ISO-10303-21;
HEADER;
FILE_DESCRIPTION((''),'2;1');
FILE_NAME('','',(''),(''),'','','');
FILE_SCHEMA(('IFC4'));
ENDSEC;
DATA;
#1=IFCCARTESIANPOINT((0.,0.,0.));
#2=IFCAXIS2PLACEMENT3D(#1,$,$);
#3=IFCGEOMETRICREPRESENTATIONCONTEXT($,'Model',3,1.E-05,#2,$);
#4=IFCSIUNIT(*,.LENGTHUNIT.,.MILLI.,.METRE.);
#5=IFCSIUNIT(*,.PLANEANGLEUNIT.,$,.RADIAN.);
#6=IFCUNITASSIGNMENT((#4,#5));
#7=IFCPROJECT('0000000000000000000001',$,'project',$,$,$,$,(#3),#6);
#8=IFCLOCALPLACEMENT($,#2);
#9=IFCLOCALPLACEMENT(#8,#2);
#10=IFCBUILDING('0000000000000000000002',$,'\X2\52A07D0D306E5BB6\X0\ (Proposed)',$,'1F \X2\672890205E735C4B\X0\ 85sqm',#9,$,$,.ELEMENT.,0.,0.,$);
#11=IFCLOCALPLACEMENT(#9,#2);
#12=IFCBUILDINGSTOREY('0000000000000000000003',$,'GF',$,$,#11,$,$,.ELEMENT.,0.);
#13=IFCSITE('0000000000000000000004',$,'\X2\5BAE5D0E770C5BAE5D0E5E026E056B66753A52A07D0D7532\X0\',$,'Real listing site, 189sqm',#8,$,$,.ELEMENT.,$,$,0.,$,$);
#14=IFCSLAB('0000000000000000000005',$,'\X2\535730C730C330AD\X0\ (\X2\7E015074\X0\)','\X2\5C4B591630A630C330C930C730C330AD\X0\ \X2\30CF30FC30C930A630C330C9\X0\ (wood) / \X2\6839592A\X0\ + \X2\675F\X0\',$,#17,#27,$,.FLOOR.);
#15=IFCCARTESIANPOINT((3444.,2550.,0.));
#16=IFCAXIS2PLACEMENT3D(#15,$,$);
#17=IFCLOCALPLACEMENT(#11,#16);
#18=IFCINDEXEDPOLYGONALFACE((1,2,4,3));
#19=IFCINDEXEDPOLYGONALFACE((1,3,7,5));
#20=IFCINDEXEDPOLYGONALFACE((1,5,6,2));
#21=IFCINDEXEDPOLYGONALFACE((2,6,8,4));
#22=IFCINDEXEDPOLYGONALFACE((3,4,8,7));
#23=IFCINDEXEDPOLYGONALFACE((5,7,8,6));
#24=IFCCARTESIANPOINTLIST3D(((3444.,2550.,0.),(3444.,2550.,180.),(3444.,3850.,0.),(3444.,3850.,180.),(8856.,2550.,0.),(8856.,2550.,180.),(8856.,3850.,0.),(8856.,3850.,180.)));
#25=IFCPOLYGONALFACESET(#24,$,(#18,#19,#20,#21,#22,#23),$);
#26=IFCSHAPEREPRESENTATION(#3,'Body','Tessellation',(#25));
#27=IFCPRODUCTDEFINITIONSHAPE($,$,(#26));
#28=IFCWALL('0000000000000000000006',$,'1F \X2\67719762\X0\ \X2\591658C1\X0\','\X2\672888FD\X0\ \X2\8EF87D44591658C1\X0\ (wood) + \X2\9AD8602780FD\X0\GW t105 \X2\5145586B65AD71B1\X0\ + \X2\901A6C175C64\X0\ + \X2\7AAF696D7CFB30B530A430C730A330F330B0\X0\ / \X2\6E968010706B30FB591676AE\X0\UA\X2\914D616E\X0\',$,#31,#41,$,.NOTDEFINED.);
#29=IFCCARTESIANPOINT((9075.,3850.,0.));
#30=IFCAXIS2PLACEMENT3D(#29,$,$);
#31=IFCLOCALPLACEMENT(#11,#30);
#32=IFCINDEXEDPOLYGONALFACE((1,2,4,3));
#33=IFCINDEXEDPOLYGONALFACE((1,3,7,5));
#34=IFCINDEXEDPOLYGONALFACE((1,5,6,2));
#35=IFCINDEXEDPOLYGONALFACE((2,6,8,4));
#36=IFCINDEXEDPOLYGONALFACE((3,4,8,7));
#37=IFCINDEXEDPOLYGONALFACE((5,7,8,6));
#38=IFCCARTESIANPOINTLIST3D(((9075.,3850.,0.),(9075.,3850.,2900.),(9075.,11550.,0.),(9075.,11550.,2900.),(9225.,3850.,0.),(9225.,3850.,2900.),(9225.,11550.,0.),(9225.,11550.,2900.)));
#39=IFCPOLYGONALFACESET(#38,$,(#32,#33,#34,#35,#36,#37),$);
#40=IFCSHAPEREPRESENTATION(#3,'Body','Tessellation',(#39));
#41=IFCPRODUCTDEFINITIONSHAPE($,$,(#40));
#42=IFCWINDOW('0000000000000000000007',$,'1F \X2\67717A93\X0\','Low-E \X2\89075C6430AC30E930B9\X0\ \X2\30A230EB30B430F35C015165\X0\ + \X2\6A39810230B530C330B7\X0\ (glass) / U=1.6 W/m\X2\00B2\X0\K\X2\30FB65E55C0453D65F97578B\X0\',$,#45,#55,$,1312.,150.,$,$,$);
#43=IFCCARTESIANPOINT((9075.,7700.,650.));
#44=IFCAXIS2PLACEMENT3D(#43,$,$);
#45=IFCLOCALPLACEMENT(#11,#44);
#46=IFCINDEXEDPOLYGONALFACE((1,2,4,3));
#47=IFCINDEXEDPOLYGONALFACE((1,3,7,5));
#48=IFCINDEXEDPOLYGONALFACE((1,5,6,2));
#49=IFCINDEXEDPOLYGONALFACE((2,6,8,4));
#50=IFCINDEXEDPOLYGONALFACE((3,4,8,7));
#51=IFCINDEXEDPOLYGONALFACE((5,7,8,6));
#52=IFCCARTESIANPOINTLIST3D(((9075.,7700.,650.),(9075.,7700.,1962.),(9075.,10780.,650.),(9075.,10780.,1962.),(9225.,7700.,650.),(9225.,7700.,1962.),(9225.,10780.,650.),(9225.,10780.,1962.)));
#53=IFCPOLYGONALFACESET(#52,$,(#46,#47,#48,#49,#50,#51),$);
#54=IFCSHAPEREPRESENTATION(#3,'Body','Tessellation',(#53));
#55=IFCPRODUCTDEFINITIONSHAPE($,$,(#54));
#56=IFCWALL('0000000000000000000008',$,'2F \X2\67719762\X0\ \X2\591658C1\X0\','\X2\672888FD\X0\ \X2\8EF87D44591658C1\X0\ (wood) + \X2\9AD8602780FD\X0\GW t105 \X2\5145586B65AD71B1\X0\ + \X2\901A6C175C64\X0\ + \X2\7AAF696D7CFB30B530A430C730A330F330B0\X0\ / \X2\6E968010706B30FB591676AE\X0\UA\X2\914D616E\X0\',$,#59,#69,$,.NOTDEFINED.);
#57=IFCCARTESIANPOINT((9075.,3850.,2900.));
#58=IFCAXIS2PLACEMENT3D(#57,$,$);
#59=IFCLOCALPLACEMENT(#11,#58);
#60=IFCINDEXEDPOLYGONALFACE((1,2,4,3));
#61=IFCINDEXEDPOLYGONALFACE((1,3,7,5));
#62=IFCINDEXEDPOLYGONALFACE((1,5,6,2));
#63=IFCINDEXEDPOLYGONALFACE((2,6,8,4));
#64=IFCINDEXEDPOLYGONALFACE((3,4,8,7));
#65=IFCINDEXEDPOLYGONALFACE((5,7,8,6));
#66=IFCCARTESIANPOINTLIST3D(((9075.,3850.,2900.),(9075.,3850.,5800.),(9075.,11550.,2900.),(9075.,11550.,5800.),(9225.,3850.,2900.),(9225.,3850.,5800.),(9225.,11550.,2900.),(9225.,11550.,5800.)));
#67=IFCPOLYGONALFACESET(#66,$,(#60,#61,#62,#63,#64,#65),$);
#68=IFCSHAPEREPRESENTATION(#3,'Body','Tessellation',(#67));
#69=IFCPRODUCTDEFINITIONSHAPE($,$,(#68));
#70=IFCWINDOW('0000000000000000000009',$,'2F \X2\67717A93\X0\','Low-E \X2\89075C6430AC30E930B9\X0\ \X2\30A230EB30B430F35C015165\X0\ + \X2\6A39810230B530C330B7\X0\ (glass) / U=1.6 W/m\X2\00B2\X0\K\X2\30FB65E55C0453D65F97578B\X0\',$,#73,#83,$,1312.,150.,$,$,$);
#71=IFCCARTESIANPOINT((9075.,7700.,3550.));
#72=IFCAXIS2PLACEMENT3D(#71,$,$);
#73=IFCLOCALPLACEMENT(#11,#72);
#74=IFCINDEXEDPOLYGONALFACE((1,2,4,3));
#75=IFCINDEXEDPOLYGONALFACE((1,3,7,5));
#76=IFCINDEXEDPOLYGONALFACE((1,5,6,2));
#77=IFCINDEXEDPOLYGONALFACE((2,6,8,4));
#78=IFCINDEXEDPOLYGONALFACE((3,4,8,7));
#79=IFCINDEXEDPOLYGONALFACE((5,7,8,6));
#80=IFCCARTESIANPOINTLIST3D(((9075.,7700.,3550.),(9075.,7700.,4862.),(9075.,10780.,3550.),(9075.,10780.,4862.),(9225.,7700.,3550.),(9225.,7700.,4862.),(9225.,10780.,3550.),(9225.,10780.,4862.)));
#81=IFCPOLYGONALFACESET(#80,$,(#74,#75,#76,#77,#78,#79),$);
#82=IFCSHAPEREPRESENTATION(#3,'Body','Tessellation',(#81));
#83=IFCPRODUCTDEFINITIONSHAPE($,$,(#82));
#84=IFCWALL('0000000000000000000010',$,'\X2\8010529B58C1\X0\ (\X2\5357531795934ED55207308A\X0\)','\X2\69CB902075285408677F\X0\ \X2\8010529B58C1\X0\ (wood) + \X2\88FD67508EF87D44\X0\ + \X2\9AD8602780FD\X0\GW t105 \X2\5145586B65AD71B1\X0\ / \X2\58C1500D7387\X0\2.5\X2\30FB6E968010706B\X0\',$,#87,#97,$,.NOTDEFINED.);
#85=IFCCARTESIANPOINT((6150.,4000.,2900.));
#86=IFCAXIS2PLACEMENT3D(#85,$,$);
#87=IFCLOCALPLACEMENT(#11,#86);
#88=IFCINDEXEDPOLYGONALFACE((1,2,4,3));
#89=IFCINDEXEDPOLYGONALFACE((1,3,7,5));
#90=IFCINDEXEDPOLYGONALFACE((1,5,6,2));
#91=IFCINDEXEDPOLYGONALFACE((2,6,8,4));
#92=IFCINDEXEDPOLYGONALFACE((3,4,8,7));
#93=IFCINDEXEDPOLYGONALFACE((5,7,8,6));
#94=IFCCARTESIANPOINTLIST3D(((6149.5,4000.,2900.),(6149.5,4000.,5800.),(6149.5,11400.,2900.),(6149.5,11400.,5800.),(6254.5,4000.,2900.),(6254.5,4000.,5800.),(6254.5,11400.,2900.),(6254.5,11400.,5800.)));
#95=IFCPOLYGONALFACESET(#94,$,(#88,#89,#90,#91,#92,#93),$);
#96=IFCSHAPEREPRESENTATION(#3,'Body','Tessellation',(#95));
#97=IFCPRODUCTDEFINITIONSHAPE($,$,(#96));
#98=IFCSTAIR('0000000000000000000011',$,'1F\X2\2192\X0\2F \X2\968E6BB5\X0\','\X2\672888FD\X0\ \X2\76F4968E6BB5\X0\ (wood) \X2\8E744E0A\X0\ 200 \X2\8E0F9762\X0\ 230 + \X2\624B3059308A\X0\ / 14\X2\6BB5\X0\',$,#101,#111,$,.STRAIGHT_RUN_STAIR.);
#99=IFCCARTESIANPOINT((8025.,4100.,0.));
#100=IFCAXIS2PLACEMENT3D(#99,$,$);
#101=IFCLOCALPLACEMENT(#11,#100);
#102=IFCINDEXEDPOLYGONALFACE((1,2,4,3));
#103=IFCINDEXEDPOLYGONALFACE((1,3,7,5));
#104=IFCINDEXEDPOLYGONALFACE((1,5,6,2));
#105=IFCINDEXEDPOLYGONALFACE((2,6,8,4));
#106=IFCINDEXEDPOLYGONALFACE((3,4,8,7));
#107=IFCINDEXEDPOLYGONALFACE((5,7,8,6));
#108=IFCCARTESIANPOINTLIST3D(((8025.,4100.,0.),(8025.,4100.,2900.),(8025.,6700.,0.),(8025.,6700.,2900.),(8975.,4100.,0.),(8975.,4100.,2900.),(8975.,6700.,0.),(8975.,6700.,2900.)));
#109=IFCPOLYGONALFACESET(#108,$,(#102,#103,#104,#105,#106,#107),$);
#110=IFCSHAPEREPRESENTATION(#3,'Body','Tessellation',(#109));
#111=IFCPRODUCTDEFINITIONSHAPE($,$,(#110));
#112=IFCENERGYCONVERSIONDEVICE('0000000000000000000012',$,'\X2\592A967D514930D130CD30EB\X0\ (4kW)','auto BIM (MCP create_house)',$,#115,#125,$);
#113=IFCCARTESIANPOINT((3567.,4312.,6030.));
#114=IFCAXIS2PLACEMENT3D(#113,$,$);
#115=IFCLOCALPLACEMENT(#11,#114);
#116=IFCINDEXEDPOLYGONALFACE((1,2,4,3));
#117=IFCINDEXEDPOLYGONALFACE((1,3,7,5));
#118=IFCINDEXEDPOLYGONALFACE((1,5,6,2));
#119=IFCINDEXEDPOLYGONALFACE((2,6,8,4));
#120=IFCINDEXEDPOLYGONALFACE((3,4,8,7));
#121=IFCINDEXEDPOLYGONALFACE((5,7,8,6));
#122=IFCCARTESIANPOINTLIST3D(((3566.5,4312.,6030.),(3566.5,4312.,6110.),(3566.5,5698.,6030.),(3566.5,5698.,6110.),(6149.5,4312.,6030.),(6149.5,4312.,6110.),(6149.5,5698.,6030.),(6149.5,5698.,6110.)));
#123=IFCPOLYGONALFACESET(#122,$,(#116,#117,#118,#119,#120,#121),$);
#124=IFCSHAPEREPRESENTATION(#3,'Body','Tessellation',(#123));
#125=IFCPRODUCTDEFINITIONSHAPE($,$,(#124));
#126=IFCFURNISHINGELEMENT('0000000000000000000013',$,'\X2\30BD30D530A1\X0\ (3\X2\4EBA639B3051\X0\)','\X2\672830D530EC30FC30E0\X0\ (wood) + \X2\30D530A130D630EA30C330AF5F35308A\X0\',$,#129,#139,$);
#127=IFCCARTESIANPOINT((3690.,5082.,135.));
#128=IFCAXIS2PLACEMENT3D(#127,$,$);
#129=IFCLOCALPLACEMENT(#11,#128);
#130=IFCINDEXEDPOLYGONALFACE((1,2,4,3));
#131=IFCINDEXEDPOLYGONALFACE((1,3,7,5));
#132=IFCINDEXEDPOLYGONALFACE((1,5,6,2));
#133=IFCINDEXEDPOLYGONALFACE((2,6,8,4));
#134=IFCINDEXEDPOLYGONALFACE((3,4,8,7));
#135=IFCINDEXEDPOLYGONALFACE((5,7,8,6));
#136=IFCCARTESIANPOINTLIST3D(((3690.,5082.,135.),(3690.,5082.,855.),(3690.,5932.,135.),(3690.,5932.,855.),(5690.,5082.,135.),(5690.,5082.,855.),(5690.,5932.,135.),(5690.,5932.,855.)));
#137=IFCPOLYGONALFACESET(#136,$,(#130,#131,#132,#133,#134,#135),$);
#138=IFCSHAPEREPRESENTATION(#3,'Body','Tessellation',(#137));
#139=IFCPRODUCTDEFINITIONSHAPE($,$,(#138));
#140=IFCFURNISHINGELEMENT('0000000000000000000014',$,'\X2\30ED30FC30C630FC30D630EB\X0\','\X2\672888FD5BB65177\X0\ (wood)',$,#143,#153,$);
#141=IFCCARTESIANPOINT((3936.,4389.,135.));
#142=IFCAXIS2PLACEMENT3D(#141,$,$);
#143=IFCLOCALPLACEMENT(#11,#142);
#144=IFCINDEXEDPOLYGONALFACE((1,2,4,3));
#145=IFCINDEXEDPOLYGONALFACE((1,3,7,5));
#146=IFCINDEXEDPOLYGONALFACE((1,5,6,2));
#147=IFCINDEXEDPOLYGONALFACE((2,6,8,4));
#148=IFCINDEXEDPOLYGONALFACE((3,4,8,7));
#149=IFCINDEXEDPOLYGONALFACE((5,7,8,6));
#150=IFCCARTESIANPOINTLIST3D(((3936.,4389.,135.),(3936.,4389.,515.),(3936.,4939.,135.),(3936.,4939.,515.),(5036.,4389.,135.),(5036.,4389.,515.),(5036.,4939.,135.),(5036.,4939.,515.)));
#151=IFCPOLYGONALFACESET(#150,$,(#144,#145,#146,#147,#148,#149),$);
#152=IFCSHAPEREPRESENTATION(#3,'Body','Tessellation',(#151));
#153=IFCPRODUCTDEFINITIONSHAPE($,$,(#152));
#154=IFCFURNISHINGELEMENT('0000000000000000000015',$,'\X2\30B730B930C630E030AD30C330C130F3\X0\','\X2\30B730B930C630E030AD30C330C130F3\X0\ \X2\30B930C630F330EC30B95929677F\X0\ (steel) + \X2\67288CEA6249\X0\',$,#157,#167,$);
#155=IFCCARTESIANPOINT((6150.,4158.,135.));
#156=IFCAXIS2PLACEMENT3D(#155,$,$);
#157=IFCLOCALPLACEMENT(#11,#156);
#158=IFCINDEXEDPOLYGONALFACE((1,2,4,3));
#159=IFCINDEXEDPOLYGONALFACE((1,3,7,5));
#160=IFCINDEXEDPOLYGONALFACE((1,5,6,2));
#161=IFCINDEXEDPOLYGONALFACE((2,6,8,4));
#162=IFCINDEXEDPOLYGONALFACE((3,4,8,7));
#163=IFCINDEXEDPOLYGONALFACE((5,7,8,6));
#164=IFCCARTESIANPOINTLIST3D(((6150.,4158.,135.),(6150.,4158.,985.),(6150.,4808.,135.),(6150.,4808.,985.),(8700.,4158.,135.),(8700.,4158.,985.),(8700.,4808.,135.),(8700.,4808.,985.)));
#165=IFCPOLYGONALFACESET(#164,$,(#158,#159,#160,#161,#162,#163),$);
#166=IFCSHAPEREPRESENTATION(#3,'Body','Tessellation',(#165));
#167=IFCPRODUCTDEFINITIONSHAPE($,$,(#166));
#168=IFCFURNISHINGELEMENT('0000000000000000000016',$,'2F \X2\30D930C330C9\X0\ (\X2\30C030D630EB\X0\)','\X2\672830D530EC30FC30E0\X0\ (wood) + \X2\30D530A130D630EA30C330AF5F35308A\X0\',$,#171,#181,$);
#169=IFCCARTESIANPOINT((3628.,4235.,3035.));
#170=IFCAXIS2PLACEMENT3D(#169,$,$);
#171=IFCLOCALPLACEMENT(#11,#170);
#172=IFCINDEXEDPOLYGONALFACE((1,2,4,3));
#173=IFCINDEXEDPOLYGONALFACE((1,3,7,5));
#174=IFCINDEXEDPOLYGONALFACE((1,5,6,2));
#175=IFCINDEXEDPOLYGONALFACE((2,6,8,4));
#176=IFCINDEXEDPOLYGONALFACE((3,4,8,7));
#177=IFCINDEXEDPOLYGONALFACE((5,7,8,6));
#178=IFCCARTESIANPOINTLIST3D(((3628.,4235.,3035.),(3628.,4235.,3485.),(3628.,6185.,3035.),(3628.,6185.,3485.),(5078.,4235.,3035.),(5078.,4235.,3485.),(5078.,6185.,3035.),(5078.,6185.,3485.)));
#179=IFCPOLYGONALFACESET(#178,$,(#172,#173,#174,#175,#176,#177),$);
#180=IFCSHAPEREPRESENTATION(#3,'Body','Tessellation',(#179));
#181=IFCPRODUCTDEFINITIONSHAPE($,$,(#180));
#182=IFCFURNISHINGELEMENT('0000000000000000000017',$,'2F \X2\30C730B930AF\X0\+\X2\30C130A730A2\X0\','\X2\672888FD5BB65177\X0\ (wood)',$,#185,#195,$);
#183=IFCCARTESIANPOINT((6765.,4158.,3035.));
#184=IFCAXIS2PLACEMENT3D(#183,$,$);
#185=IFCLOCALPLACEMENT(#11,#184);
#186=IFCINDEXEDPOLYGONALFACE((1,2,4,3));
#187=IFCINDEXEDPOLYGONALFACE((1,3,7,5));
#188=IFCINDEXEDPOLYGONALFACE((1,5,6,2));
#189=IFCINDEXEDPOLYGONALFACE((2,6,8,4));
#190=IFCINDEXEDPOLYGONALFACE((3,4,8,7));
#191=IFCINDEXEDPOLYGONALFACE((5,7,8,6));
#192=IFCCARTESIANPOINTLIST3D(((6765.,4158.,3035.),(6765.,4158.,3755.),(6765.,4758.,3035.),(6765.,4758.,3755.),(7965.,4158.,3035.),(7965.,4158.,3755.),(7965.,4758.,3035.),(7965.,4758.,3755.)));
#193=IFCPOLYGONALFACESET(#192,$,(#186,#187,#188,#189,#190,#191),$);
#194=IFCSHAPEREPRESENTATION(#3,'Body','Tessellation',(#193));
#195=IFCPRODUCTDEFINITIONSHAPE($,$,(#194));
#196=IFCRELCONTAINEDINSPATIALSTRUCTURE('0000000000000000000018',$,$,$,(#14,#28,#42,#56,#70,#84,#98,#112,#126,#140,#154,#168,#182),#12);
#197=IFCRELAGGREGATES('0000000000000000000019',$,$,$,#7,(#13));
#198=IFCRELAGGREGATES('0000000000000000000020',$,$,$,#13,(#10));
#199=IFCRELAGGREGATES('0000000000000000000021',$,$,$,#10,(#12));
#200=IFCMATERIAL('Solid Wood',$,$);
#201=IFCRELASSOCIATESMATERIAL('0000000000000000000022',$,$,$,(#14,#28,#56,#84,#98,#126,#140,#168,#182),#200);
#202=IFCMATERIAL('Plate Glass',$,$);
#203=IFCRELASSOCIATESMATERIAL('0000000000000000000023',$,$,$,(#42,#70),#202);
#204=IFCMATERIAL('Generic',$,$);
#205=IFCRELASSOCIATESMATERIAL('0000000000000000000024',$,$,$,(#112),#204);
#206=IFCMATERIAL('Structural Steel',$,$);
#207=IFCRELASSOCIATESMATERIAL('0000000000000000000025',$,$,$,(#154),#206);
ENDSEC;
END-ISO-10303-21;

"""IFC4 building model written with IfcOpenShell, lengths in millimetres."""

from ifc_helpers import new_model, si_unit, frame, frame_2d, origin, place, context, project, spatial, rectangle, extrude, material, element, fill, save


model = new_model("IFC4")

# Units and contexts
model_context = context("Model", 3, precision=1e-05, world=origin())
ifc_project = project(units=[si_unit("LENGTHUNIT", "METRE", prefix="MILLI"), si_unit("PLANEANGLEUNIT", "RADIAN")], contexts=[model_context])

# Site, building, storey
site_placement = place(None, origin())
site = spatial("IfcSite", under=ifc_project, at=site_placement, Name="宮崎県宮崎市清武町加納甲", ObjectType="Real listing site, 189sqm", CompositionType="ELEMENT", RefElevation=0.0)
building_placement = place(site_placement, origin())
building = spatial("IfcBuilding", under=site, at=building_placement, Name="加納の家 (Proposed)", ObjectType="1F 木造平屋 85sqm", CompositionType="ELEMENT", ElevationOfRefHeight=0.0, ElevationOfTerrain=0.0)
storey_placement = place(building_placement, origin())
storey = spatial("IfcBuildingStorey", under=building, at=storey_placement, Name="GF", CompositionType="ELEMENT", Elevation=0.0)

# Slab
ifc_material_1 = material(Name="Solid Wood")
slab_placement = place(storey_placement, frame((3444.0, 2550.0, 0.0)))
element("IfcSlab", 1, at=slab_placement, inside=storey, material=ifc_material_1, Name="南デッキ (縁側)", Description="屋外ウッドデッキ ハードウッド (wood) / 根太 + 束", PredefinedType="FLOOR", context=model_context, shape_type="SweptSolid", body=[
    extrude(rectangle(XDim=5412.0, YDim=1300.0, at=frame_2d((2706.0, 650.0))), frame((3444.0, 2550.0, 0.0)), (0.0, 0.0, 1.0), 180.0),
])

# Wall, opening, window
wall_1_placement = place(storey_placement, frame((9075.0, 3850.0, 0.0)))
wall_1 = element("IfcWall", 2, at=wall_1_placement, inside=storey, material=ifc_material_1, Name="1F 東面 外壁", Description="木製 軸組外壁 (wood) + 高性能GW t105 充填断熱 + 通気層 + 窯業系サイディング / 準耐火・外皮UA配慮", PredefinedType="NOTDEFINED", context=model_context, shape_type="SweptSolid", body=[
    extrude(rectangle(XDim=150.0, YDim=7700.0, at=frame_2d((75.0, 3850.0))), frame((9075.0, 3850.0, 0.0)), (0.0, 0.0, 1.0), 2900.0),
])
opening_1_placement = place(storey_placement, frame((9075.0, 7700.0, 650.0)))
opening_1 = element("IfcOpeningElement", 3, at=opening_1_placement, cuts=wall_1, PredefinedType="NOTDEFINED", context=model_context, shape_type="SweptSolid", body=[
    extrude(rectangle(XDim=150.0, YDim=3080.0, at=frame_2d((75.0, 1540.0))), frame((9075.0, 7700.0, 650.0)), (0.0, 0.0, 1.0), 1312.0),
])
ifc_material_2 = material(Name="Plate Glass")
window_1_placement = place(storey_placement, frame((9075.0, 7700.0, 650.0)))
window_1 = element("IfcWindow", 4, at=window_1_placement, inside=storey, material=ifc_material_2, Name="1F 東窓", Description="Low-E 複層ガラス アルゴン封入 + 樹脂サッシ (glass) / U=1.6 W/m²K・日射取得型", OverallHeight=1312.0, OverallWidth=150.0, context=model_context, shape_type="SweptSolid", body=[
    extrude(rectangle(XDim=150.0, YDim=3080.0, at=frame_2d((75.0, 1540.0))), frame((9075.0, 7700.0, 650.0)), (0.0, 0.0, 1.0), 1312.0),
])
fill(opening_1, window_1)

# Wall, opening, window
wall_2_placement = place(storey_placement, frame((9075.0, 3850.0, 2900.0)))
wall_2 = element("IfcWall", 5, at=wall_2_placement, inside=storey, material=ifc_material_1, Name="2F 東面 外壁", Description="木製 軸組外壁 (wood) + 高性能GW t105 充填断熱 + 通気層 + 窯業系サイディング / 準耐火・外皮UA配慮", PredefinedType="NOTDEFINED", context=model_context, shape_type="SweptSolid", body=[
    extrude(rectangle(XDim=150.0, YDim=7700.0, at=frame_2d((75.0, 3850.0))), frame((9075.0, 3850.0, 2900.0)), (0.0, 0.0, 1.0), 2900.0),
])
opening_2_placement = place(storey_placement, frame((9075.0, 7700.0, 3550.0)))
opening_2 = element("IfcOpeningElement", 6, at=opening_2_placement, cuts=wall_2, PredefinedType="NOTDEFINED", context=model_context, shape_type="SweptSolid", body=[
    extrude(rectangle(XDim=150.0, YDim=3080.0, at=frame_2d((75.0, 1540.0))), frame((9075.0, 7700.0, 3550.0)), (0.0, 0.0, 1.0), 1312.0),
])
window_2_placement = place(storey_placement, frame((9075.0, 7700.0, 3550.0)))
window_2 = element("IfcWindow", 7, at=window_2_placement, inside=storey, material=ifc_material_2, Name="2F 東窓", Description="Low-E 複層ガラス アルゴン封入 + 樹脂サッシ (glass) / U=1.6 W/m²K・日射取得型", OverallHeight=1312.0, OverallWidth=150.0, context=model_context, shape_type="SweptSolid", body=[
    extrude(rectangle(XDim=150.0, YDim=3080.0, at=frame_2d((75.0, 1540.0))), frame((9075.0, 7700.0, 3550.0)), (0.0, 0.0, 1.0), 1312.0),
])
fill(opening_2, window_2)

# Wall
wall_3_placement = place(storey_placement, frame((6150.0, 4000.0, 2900.0)))
element("IfcWall", 8, at=wall_3_placement, inside=storey, material=ifc_material_1, Name="耐力壁 (南北間仕切り)", Description="構造用合板 耐力壁 (wood) + 製材軸組 + 高性能GW t105 充填断熱 / 壁倍率2.5・準耐火", PredefinedType="NOTDEFINED", context=model_context, shape_type="SweptSolid", body=[
    extrude(rectangle(XDim=105.0, YDim=7400.0, at=frame_2d((52.0, 3700.0))), frame((6150.0, 4000.0, 2900.0)), (0.0, 0.0, 1.0), 2900.0),
])

# Stair
stair_placement = place(storey_placement, frame((8025.0, 4100.0, 0.0)))
element("IfcStair", 9, at=stair_placement, inside=storey, material=ifc_material_1, Name="1F→2F 階段", Description="木製 直階段 (wood) 蹴上 200 踏面 230 + 手すり / 14段", PredefinedType="STRAIGHT_RUN_STAIR", context=model_context, shape_type="SweptSolid", body=[
    extrude(rectangle(XDim=950.0, YDim=2600.0, at=frame_2d((475.0, 1300.0))), frame((8025.0, 4100.0, 0.0)), (0.0, 0.0, 1.0), 2900.0),
])

# Energy conversion device
ifc_material_3 = material(Name="Generic")
energy_conversion_device_placement = place(storey_placement, frame((3567.0, 4312.0, 6030.0)))
element("IfcEnergyConversionDevice", 10, at=energy_conversion_device_placement, inside=storey, material=ifc_material_3, Name="太陽光パネル (4kW)", Description="auto BIM (MCP create_house)", context=model_context, shape_type="SweptSolid", body=[
    extrude(rectangle(XDim=2583.0, YDim=1386.0, at=frame_2d((1291.0, 693.0))), frame((3567.0, 4312.0, 6030.0)), (0.0, 0.0, 1.0), 80.0),
])

# Furnishing elements
furnishing_1_placement = place(storey_placement, frame((3690.0, 5082.0, 135.0)))
element("IfcFurnishingElement", 11, at=furnishing_1_placement, inside=storey, material=ifc_material_1, Name="ソファ (3人掛け)", Description="木フレーム (wood) + ファブリック張り", context=model_context, shape_type="SweptSolid", body=[
    extrude(rectangle(XDim=2000.0, YDim=850.0, at=frame_2d((1000.0, 425.0))), frame((3690.0, 5082.0, 135.0)), (0.0, 0.0, 1.0), 720.0),
])
furnishing_2_placement = place(storey_placement, frame((3936.0, 4389.0, 135.0)))
element("IfcFurnishingElement", 12, at=furnishing_2_placement, inside=storey, material=ifc_material_1, Name="ローテーブル", Description="木製家具 (wood)", context=model_context, shape_type="SweptSolid", body=[
    extrude(rectangle(XDim=1100.0, YDim=550.0, at=frame_2d((550.0, 275.0))), frame((3936.0, 4389.0, 135.0)), (0.0, 0.0, 1.0), 380.0),
])
ifc_material_4 = material(Name="Structural Steel")
furnishing_3_placement = place(storey_placement, frame((6150.0, 4158.0, 135.0)))
element("IfcFurnishingElement", 13, at=furnishing_3_placement, inside=storey, material=ifc_material_4, Name="システムキッチン", Description="システムキッチン ステンレス天板 (steel) + 木質扉", context=model_context, shape_type="SweptSolid", body=[
    extrude(rectangle(XDim=2550.0, YDim=650.0, at=frame_2d((1275.0, 325.0))), frame((6150.0, 4158.0, 135.0)), (0.0, 0.0, 1.0), 850.0),
])
furnishing_4_placement = place(storey_placement, frame((3628.0, 4235.0, 3035.0)))
element("IfcFurnishingElement", 14, at=furnishing_4_placement, inside=storey, material=ifc_material_1, Name="2F ベッド (ダブル)", Description="木フレーム (wood) + ファブリック張り", context=model_context, shape_type="SweptSolid", body=[
    extrude(rectangle(XDim=1450.0, YDim=1950.0, at=frame_2d((725.0, 975.0))), frame((3628.0, 4235.0, 3035.0)), (0.0, 0.0, 1.0), 450.0),
])
furnishing_5_placement = place(storey_placement, frame((6765.0, 4158.0, 3035.0)))
element("IfcFurnishingElement", 15, at=furnishing_5_placement, inside=storey, material=ifc_material_1, Name="2F デスク+チェア", Description="木製家具 (wood)", context=model_context, shape_type="SweptSolid", body=[
    extrude(rectangle(XDim=1200.0, YDim=600.0, at=frame_2d((600.0, 300.0))), frame((6765.0, 4158.0, 3035.0)), (0.0, 0.0, 1.0), 720.0),
])

save(model, "model.ifc")
